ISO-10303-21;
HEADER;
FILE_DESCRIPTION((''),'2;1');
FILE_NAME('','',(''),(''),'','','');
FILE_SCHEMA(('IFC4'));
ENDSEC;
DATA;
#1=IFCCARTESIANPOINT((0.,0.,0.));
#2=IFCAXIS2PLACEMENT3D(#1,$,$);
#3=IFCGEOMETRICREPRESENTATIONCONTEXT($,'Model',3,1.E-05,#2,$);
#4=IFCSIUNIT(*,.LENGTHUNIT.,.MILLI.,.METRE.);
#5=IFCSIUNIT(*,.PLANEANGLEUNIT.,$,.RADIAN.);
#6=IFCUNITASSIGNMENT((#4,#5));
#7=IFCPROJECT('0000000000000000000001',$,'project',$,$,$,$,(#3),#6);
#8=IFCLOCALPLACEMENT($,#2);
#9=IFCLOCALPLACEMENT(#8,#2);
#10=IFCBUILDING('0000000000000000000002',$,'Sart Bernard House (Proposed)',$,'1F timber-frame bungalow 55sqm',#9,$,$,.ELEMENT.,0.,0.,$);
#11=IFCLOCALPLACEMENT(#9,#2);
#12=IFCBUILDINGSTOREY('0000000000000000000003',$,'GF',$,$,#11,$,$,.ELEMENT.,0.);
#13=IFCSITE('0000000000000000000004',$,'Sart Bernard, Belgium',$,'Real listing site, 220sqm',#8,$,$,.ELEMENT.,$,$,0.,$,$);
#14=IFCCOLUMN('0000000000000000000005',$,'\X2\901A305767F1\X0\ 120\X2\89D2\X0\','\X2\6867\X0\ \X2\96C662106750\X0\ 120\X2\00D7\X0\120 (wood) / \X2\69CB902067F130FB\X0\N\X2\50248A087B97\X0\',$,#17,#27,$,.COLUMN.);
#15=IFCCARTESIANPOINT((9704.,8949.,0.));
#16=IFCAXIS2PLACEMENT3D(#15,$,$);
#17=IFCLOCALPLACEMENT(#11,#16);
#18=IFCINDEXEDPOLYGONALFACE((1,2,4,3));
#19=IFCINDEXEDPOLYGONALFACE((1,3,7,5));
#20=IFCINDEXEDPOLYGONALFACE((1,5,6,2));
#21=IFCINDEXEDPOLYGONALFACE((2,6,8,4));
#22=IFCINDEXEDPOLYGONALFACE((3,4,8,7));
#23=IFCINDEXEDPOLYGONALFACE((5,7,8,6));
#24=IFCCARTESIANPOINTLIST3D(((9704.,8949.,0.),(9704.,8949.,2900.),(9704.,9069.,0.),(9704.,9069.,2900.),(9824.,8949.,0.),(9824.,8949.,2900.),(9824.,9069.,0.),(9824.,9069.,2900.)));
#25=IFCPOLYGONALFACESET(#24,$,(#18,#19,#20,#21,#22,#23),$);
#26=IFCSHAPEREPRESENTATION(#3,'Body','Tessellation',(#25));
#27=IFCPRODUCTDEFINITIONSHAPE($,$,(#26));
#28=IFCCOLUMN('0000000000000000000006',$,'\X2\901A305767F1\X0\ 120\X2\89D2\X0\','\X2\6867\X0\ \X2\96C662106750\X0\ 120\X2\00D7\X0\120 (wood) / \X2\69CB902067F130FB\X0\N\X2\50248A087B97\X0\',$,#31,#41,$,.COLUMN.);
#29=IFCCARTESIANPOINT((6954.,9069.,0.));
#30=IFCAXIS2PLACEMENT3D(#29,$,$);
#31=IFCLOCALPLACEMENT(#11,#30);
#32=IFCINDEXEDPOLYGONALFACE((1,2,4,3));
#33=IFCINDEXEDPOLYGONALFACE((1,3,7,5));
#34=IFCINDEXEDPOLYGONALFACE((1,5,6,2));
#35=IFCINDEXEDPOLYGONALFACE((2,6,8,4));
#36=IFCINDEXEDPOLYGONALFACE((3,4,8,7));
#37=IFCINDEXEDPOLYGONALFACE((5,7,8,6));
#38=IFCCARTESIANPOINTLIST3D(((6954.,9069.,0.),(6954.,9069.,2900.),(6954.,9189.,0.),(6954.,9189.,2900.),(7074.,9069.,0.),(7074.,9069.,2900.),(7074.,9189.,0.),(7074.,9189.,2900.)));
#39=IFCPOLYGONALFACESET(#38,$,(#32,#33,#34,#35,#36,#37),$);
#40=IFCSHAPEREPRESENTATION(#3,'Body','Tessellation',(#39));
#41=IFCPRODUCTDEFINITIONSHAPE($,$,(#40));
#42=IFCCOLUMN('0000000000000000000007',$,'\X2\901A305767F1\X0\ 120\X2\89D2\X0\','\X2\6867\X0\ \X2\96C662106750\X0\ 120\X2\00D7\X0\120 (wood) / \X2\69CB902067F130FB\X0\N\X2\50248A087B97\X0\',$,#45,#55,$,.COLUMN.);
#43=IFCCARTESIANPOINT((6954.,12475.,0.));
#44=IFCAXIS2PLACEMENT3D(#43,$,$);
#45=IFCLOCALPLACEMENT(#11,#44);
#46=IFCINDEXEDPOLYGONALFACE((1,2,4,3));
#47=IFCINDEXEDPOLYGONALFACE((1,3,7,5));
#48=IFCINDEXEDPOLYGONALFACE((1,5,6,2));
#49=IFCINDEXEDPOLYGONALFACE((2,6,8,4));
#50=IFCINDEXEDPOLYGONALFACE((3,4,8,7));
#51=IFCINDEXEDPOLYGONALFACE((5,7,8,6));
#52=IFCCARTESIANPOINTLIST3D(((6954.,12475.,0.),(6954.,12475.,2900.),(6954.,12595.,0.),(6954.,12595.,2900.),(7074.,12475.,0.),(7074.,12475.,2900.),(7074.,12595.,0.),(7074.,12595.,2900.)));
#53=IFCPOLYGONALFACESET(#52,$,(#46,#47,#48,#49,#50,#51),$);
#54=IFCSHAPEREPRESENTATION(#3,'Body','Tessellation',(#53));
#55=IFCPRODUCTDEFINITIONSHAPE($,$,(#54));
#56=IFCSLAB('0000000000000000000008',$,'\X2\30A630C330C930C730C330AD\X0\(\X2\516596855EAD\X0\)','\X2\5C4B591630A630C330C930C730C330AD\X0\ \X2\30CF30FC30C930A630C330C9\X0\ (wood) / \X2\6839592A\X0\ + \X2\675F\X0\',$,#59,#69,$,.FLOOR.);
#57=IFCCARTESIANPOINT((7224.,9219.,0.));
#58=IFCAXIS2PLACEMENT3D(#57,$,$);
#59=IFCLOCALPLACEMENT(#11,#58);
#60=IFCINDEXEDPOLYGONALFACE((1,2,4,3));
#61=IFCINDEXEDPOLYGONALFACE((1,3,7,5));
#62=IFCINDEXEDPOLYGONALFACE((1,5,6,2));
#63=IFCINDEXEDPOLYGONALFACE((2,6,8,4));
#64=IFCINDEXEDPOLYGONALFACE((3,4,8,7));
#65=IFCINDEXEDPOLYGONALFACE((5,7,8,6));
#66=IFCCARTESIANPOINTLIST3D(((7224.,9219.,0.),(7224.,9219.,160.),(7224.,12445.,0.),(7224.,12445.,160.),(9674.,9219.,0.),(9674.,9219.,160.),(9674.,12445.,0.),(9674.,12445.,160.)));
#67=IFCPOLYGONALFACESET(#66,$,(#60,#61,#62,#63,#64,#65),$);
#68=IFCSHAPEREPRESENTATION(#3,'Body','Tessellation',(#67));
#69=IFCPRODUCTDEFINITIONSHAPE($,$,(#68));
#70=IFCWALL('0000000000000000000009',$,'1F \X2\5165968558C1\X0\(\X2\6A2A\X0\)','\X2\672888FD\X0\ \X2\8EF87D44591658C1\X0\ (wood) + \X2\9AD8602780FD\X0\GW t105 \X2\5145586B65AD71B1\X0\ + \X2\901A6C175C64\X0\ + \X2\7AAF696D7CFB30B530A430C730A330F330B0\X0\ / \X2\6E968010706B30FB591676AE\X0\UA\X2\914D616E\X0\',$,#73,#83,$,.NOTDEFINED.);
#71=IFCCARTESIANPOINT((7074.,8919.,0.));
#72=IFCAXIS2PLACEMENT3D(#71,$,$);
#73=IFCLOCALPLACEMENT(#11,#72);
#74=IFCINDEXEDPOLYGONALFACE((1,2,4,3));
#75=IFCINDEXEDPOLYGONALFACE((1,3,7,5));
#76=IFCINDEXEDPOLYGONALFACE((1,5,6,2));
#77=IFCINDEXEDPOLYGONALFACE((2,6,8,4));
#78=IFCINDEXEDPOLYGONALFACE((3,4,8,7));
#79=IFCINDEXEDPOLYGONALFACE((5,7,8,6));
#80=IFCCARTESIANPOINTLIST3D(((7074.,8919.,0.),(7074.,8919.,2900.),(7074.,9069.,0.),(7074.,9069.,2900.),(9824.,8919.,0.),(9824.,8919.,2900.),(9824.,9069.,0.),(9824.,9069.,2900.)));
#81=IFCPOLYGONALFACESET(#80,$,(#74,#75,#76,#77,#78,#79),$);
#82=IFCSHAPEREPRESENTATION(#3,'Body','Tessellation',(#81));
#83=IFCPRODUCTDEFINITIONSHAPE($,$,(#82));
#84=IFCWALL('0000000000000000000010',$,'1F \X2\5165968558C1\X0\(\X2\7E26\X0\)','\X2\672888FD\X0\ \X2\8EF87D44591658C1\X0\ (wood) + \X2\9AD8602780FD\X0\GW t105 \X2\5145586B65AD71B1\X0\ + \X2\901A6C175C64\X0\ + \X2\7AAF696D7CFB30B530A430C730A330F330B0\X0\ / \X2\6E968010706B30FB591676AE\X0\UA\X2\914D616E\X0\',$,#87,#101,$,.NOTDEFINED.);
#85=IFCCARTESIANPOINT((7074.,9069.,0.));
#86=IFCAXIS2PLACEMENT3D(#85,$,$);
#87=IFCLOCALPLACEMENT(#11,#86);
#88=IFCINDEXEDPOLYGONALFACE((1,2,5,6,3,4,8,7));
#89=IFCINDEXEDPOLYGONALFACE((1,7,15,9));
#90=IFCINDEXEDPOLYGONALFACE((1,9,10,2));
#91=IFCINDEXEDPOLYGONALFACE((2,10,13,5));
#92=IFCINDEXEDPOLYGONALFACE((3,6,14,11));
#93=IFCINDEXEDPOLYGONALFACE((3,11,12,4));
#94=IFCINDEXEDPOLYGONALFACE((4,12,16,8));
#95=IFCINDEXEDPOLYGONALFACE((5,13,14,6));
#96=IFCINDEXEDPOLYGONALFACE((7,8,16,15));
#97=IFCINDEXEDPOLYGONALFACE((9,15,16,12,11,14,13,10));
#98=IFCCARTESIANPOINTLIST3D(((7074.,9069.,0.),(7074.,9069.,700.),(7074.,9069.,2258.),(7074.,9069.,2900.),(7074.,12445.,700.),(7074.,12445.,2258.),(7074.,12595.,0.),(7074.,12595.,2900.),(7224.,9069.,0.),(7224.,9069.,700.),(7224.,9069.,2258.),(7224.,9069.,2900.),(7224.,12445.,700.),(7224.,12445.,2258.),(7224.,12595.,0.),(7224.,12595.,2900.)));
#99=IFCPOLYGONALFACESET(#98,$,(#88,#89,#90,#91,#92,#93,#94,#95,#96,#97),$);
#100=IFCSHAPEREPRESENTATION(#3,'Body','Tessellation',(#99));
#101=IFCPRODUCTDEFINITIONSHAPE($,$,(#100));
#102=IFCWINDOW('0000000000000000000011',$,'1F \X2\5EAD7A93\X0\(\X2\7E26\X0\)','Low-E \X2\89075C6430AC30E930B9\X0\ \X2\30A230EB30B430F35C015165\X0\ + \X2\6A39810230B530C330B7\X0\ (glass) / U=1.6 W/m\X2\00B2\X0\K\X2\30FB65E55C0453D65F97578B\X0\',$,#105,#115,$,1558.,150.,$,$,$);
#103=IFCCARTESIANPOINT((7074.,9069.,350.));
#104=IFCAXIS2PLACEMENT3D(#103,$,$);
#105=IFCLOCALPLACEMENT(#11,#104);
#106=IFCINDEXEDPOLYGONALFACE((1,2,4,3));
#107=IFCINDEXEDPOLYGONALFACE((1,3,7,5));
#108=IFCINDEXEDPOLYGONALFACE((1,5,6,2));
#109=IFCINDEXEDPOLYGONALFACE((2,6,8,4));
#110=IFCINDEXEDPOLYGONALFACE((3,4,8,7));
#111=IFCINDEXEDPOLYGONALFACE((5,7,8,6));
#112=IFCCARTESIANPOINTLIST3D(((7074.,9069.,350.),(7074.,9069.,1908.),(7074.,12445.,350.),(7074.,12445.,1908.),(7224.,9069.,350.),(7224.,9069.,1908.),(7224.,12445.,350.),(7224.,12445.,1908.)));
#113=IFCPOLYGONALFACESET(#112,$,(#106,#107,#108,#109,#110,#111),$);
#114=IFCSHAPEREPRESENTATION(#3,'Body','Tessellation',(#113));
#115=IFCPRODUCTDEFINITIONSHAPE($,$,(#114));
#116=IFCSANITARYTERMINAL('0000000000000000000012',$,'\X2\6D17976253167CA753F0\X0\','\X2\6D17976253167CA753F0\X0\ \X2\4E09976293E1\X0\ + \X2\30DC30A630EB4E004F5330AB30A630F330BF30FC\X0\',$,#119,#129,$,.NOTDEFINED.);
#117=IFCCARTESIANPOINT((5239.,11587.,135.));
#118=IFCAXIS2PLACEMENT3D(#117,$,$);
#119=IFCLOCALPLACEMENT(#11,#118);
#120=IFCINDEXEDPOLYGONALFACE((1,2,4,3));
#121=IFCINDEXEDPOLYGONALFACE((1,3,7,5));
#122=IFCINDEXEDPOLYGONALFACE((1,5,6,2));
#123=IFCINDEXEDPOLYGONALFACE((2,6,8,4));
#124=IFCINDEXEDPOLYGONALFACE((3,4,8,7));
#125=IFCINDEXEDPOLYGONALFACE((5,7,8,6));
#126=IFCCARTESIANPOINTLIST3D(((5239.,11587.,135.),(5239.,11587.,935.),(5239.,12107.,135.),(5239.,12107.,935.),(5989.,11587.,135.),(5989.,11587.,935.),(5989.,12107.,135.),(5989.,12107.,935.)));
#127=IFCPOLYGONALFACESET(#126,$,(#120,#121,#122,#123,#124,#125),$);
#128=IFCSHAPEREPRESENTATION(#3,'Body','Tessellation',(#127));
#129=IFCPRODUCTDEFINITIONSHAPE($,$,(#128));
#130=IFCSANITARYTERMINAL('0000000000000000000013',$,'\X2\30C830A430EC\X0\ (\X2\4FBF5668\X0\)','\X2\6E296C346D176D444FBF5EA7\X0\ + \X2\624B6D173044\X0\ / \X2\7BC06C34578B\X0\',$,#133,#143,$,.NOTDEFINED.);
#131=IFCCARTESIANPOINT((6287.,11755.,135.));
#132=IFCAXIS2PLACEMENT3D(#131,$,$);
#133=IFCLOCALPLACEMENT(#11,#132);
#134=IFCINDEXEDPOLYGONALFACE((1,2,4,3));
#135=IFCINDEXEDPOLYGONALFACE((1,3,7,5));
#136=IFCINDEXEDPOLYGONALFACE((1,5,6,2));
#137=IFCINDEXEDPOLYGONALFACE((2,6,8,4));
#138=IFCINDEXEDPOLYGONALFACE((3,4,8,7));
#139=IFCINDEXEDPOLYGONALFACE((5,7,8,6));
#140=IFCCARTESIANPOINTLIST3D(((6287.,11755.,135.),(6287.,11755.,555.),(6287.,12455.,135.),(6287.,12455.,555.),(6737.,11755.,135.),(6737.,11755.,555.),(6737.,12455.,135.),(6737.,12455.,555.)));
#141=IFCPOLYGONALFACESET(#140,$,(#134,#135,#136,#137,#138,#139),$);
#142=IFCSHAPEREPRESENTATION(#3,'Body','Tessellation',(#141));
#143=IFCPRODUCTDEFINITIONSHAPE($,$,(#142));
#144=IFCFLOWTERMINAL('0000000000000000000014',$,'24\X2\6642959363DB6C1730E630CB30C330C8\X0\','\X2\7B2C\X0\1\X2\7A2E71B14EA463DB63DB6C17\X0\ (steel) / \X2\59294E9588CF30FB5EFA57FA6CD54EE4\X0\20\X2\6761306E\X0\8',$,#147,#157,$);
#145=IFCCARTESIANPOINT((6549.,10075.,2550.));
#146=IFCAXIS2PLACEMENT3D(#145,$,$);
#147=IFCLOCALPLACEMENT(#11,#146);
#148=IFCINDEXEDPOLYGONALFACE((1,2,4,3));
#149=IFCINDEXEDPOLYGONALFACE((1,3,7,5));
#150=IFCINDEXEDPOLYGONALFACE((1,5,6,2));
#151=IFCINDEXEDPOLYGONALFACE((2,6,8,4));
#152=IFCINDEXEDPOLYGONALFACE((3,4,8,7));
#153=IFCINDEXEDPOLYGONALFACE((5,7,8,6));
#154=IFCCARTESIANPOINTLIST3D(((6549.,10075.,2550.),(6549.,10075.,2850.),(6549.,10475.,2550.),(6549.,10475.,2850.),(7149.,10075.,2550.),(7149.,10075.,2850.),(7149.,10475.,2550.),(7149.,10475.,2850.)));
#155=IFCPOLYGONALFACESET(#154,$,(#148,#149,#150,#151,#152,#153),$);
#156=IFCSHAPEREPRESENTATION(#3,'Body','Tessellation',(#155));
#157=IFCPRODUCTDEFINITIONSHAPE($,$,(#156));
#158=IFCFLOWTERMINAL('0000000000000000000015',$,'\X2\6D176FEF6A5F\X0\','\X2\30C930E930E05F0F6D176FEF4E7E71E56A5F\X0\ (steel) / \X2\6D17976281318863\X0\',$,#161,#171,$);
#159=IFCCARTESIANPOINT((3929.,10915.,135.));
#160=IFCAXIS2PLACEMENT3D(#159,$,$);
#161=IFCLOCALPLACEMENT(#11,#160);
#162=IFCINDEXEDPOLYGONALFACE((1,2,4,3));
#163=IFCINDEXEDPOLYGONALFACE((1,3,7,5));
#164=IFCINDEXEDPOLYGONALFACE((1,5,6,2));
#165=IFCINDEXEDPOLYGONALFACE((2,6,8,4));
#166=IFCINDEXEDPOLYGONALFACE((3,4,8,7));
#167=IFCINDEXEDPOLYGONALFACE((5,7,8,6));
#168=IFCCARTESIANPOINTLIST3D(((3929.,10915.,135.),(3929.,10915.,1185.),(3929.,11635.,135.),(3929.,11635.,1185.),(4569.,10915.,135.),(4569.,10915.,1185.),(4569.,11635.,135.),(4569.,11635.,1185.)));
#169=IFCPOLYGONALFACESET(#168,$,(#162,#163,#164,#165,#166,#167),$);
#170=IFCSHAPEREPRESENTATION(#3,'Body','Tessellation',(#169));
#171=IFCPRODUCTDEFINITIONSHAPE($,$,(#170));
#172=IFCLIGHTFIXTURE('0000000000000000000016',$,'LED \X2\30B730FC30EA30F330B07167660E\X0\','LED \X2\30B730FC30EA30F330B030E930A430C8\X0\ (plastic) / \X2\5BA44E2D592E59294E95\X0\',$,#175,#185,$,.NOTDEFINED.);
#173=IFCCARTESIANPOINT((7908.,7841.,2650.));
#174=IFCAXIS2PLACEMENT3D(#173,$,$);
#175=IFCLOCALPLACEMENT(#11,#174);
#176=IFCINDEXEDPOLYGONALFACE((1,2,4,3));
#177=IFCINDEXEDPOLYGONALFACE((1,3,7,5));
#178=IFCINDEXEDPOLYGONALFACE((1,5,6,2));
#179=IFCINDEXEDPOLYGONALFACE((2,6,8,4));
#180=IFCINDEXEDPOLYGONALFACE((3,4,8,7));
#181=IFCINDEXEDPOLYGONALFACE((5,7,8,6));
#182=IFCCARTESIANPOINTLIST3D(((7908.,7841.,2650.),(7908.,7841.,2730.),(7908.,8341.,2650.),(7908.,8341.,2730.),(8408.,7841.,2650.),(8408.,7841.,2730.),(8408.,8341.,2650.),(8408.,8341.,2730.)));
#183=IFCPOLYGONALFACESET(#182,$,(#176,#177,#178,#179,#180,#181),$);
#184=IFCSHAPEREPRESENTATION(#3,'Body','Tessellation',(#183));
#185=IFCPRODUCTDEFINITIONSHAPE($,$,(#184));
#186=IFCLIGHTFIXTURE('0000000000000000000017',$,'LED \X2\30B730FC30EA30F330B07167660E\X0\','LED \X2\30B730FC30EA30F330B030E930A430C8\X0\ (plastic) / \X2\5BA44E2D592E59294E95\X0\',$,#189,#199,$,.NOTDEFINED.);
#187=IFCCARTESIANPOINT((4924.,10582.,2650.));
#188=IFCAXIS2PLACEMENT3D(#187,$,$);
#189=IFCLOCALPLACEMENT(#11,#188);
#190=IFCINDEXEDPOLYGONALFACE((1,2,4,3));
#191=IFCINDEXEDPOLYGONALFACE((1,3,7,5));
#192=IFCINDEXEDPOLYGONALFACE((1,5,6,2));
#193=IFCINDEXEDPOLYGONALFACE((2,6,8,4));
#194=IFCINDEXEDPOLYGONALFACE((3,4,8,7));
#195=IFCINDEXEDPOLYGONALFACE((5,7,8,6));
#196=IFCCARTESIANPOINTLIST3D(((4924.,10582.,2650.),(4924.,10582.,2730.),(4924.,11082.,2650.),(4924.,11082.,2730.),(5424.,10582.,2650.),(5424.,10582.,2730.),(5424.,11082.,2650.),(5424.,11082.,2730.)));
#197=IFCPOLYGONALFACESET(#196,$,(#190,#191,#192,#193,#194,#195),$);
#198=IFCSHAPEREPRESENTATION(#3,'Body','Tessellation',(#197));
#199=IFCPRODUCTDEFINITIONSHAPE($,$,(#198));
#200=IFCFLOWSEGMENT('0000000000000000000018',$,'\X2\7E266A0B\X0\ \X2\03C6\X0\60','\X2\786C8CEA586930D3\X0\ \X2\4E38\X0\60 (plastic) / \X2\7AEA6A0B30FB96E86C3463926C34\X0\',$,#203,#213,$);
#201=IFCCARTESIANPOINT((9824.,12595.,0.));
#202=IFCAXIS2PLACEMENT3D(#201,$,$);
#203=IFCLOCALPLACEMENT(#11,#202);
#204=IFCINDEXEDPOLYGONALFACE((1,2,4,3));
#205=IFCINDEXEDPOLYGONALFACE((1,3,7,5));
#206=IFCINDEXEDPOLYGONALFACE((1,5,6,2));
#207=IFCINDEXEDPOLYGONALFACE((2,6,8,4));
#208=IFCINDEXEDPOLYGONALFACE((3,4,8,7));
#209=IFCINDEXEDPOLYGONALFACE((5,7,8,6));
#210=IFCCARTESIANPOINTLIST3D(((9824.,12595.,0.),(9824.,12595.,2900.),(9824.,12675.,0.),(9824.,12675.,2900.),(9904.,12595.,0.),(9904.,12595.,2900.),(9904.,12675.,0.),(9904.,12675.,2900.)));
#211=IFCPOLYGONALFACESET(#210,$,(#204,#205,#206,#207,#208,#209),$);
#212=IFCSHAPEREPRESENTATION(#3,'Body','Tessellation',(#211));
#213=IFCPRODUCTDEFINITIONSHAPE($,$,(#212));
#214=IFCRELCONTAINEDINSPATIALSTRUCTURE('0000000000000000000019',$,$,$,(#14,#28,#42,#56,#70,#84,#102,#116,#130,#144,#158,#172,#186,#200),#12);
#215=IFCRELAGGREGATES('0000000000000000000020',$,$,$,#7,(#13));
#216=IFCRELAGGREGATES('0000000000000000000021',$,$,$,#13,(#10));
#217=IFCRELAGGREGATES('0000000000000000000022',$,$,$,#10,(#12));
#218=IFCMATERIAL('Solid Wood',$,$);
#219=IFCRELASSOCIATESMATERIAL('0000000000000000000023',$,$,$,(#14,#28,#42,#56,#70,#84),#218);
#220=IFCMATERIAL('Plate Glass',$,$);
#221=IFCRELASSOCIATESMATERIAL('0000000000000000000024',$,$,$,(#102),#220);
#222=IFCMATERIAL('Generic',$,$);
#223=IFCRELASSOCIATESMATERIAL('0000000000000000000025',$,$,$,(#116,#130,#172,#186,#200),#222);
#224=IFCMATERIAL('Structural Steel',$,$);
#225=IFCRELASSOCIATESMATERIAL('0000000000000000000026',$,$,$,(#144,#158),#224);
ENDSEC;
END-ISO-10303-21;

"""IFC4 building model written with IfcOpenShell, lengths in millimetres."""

from ifc_helpers import new_model, si_unit, frame, frame_2d, origin, place, context, project, spatial, rectangle, extrude, material, element, fill, save


model = new_model("IFC4")

# Units and contexts
model_context = context("Model", 3, precision=1e-05, world=origin())
ifc_project = project(units=[si_unit("LENGTHUNIT", "METRE", prefix="MILLI"), si_unit("PLANEANGLEUNIT", "RADIAN")], contexts=[model_context])

# Site, building, storey
site_placement = place(None, origin())
site = spatial("IfcSite", under=ifc_project, at=site_placement, Name="Sart Bernard, Belgium", ObjectType="Real listing site, 220sqm", CompositionType="ELEMENT", RefElevation=0.0)
building_placement = place(site_placement, origin())
building = spatial("IfcBuilding", under=site, at=building_placement, Name="Sart Bernard House (Proposed)", ObjectType="1F timber-frame bungalow 55sqm", CompositionType="ELEMENT", ElevationOfRefHeight=0.0, ElevationOfTerrain=0.0)
storey_placement = place(building_placement, origin())
storey = spatial("IfcBuildingStorey", under=building, at=storey_placement, Name="GF", CompositionType="ELEMENT", Elevation=0.0)

# Columns
ifc_material_1 = material(Name="Solid Wood")
column_1_placement = place(storey_placement, frame((9704.0, 8949.0, 0.0)))
element("IfcColumn", 1, at=column_1_placement, inside=storey, material=ifc_material_1, Name="通し柱 120角", Description="桧 集成材 120×120 (wood) / 構造柱・N値計算", PredefinedType="COLUMN", context=model_context, shape_type="SweptSolid", body=[
    extrude(rectangle(XDim=120.0, YDim=120.0, at=frame_2d((60.0, 60.0))), frame((9704.0, 8949.0, 0.0)), (0.0, 0.0, 1.0), 2900.0),
])
column_2_placement = place(storey_placement, frame((6954.0, 9069.0, 0.0)))
element("IfcColumn", 2, at=column_2_placement, inside=storey, material=ifc_material_1, Name="通し柱 120角", Description="桧 集成材 120×120 (wood) / 構造柱・N値計算", PredefinedType="COLUMN", context=model_context, shape_type="SweptSolid", body=[
    extrude(rectangle(XDim=120.0, YDim=120.0, at=frame_2d((60.0, 60.0))), frame((6954.0, 9069.0, 0.0)), (0.0, 0.0, 1.0), 2900.0),
])
column_3_placement = place(storey_placement, frame((6954.0, 12475.0, 0.0)))
element("IfcColumn", 3, at=column_3_placement, inside=storey, material=ifc_material_1, Name="通し柱 120角", Description="桧 集成材 120×120 (wood) / 構造柱・N値計算", PredefinedType="COLUMN", context=model_context, shape_type="SweptSolid", body=[
    extrude(rectangle(XDim=120.0, YDim=120.0, at=frame_2d((60.0, 60.0))), frame((6954.0, 12475.0, 0.0)), (0.0, 0.0, 1.0), 2900.0),
])

# Slab
slab_placement = place(storey_placement, frame((7224.0, 9219.0, 0.0)))
element("IfcSlab", 4, at=slab_placement, inside=storey, material=ifc_material_1, Name="ウッドデッキ(入隅庭)", Description="屋外ウッドデッキ ハードウッド (wood) / 根太 + 束", PredefinedType="FLOOR", context=model_context, shape_type="SweptSolid", body=[
    extrude(rectangle(XDim=2450.0, YDim=3226.0, at=frame_2d((1225.0, 1613.0))), frame((7224.0, 9219.0, 0.0)), (0.0, 0.0, 1.0), 160.0),
])

# Wall
wall_1_placement = place(storey_placement, frame((7074.0, 8919.0, 0.0)))
element("IfcWall", 5, at=wall_1_placement, inside=storey, material=ifc_material_1, Name="1F 入隅壁(横)", Description="木製 軸組外壁 (wood) + 高性能GW t105 充填断熱 + 通気層 + 窯業系サイディング / 準耐火・外皮UA配慮", PredefinedType="NOTDEFINED", context=model_context, shape_type="SweptSolid", body=[
    extrude(rectangle(XDim=2750.0, YDim=150.0, at=frame_2d((1375.0, 75.0))), frame((7074.0, 8919.0, 0.0)), (0.0, 0.0, 1.0), 2900.0),
])

# Wall, opening, window
wall_2_placement = place(storey_placement, frame((7074.0, 9069.0, 0.0)))
wall_2 = element("IfcWall", 6, at=wall_2_placement, inside=storey, material=ifc_material_1, Name="1F 入隅壁(縦)", Description="木製 軸組外壁 (wood) + 高性能GW t105 充填断熱 + 通気層 + 窯業系サイディング / 準耐火・外皮UA配慮", PredefinedType="NOTDEFINED", context=model_context, shape_type="SweptSolid", body=[
    extrude(rectangle(XDim=150.0, YDim=3526.0, at=frame_2d((75.0, 1763.0))), frame((7074.0, 9069.0, 0.0)), (0.0, 0.0, 1.0), 2900.0),
])
opening_placement = place(storey_placement, frame((7074.0, 9069.0, 350.0)))
opening = element("IfcOpeningElement", 7, at=opening_placement, cuts=wall_2, PredefinedType="NOTDEFINED", context=model_context, shape_type="SweptSolid", body=[
    extrude(rectangle(XDim=150.0, YDim=3376.0, at=frame_2d((75.0, 1688.0))), frame((7074.0, 9069.0, 350.0)), (0.0, 0.0, 1.0), 1558.0),
])
ifc_material_2 = material(Name="Plate Glass")
window_placement = place(storey_placement, frame((7074.0, 9069.0, 350.0)))
window = element("IfcWindow", 8, at=window_placement, inside=storey, material=ifc_material_2, Name="1F 庭窓(縦)", Description="Low-E 複層ガラス アルゴン封入 + 樹脂サッシ (glass) / U=1.6 W/m²K・日射取得型", OverallHeight=1558.0, OverallWidth=150.0, context=model_context, shape_type="SweptSolid", body=[
    extrude(rectangle(XDim=150.0, YDim=3376.0, at=frame_2d((75.0, 1688.0))), frame((7074.0, 9069.0, 350.0)), (0.0, 0.0, 1.0), 1558.0),
])
fill(opening, window)

# Sanitary terminals
ifc_material_3 = material(Name="Generic")
sanitary_terminal_1_placement = place(storey_placement, frame((5239.0, 11587.0, 135.0)))
element("IfcSanitaryTerminal", 9, at=sanitary_terminal_1_placement, inside=storey, material=ifc_material_3, Name="洗面化粧台", Description="洗面化粧台 三面鏡 + ボウル一体カウンター", PredefinedType="NOTDEFINED", context=model_context, shape_type="SweptSolid", body=[
    extrude(rectangle(XDim=750.0, YDim=520.0, at=frame_2d((375.0, 260.0))), frame((5239.0, 11587.0, 135.0)), (0.0, 0.0, 1.0), 800.0),
])
sanitary_terminal_2_placement = place(storey_placement, frame((6287.0, 11755.0, 135.0)))
element("IfcSanitaryTerminal", 10, at=sanitary_terminal_2_placement, inside=storey, material=ifc_material_3, Name="トイレ (便器)", Description="温水洗浄便座 + 手洗い / 節水型", PredefinedType="NOTDEFINED", context=model_context, shape_type="SweptSolid", body=[
    extrude(rectangle(XDim=450.0, YDim=700.0, at=frame_2d((225.0, 350.0))), frame((6287.0, 11755.0, 135.0)), (0.0, 0.0, 1.0), 420.0),
])

# Flow terminals
ifc_material_4 = material(Name="Structural Steel")
flow_terminal_1_placement = place(storey_placement, frame((6549.0, 10075.0, 2550.0)))
element("IfcFlowTerminal", 11, at=flow_terminal_1_placement, inside=storey, material=ifc_material_4, Name="24時間換気ユニット", Description="第1種熱交換換気 (steel) / 天井裏・建基法令20条の8", context=model_context, shape_type="SweptSolid", body=[
    extrude(rectangle(XDim=600.0, YDim=400.0, at=frame_2d((300.0, 200.0))), frame((6549.0, 10075.0, 2550.0)), (0.0, 0.0, 1.0), 300.0),
])
flow_terminal_2_placement = place(storey_placement, frame((3929.0, 10915.0, 135.0)))
element("IfcFlowTerminal", 12, at=flow_terminal_2_placement, inside=storey, material=ifc_material_4, Name="洗濯機", Description="ドラム式洗濯乾燥機 (steel) / 洗面脱衣", context=model_context, shape_type="SweptSolid", body=[
    extrude(rectangle(XDim=640.0, YDim=720.0, at=frame_2d((320.0, 360.0))), frame((3929.0, 10915.0, 135.0)), (0.0, 0.0, 1.0), 1050.0),
])

# Light fixtures
light_fixture_1_placement = place(storey_placement, frame((7908.0, 7841.0, 2650.0)))
element("IfcLightFixture", 13, at=light_fixture_1_placement, inside=storey, material=ifc_material_3, Name="LED シーリング照明", Description="LED シーリングライト (plastic) / 室中央天井", PredefinedType="NOTDEFINED", context=model_context, shape_type="SweptSolid", body=[
    extrude(rectangle(XDim=500.0, YDim=500.0, at=frame_2d((250.0, 250.0))), frame((7908.0, 7841.0, 2650.0)), (0.0, 0.0, 1.0), 80.0),
])
light_fixture_2_placement = place(storey_placement, frame((4924.0, 10582.0, 2650.0)))
element("IfcLightFixture", 14, at=light_fixture_2_placement, inside=storey, material=ifc_material_3, Name="LED シーリング照明", Description="LED シーリングライト (plastic) / 室中央天井", PredefinedType="NOTDEFINED", context=model_context, shape_type="SweptSolid", body=[
    extrude(rectangle(XDim=500.0, YDim=500.0, at=frame_2d((250.0, 250.0))), frame((4924.0, 10582.0, 2650.0)), (0.0, 0.0, 1.0), 80.0),
])

# Flow segment
flow_segment_placement = place(storey_placement, frame((9824.0, 12595.0, 0.0)))
element("IfcFlowSegment", 15, at=flow_segment_placement, inside=storey, material=ifc_material_3, Name="縦樋 φ60", Description="硬質塩ビ 丸60 (plastic) / 竪樋・雨水排水", context=model_context, shape_type="SweptSolid", body=[
    extrude(rectangle(XDim=80.0, YDim=80.0, at=frame_2d((40.0, 40.0))), frame((9824.0, 12595.0, 0.0)), (0.0, 0.0, 1.0), 2900.0),
])

save(model, "model.ifc")
